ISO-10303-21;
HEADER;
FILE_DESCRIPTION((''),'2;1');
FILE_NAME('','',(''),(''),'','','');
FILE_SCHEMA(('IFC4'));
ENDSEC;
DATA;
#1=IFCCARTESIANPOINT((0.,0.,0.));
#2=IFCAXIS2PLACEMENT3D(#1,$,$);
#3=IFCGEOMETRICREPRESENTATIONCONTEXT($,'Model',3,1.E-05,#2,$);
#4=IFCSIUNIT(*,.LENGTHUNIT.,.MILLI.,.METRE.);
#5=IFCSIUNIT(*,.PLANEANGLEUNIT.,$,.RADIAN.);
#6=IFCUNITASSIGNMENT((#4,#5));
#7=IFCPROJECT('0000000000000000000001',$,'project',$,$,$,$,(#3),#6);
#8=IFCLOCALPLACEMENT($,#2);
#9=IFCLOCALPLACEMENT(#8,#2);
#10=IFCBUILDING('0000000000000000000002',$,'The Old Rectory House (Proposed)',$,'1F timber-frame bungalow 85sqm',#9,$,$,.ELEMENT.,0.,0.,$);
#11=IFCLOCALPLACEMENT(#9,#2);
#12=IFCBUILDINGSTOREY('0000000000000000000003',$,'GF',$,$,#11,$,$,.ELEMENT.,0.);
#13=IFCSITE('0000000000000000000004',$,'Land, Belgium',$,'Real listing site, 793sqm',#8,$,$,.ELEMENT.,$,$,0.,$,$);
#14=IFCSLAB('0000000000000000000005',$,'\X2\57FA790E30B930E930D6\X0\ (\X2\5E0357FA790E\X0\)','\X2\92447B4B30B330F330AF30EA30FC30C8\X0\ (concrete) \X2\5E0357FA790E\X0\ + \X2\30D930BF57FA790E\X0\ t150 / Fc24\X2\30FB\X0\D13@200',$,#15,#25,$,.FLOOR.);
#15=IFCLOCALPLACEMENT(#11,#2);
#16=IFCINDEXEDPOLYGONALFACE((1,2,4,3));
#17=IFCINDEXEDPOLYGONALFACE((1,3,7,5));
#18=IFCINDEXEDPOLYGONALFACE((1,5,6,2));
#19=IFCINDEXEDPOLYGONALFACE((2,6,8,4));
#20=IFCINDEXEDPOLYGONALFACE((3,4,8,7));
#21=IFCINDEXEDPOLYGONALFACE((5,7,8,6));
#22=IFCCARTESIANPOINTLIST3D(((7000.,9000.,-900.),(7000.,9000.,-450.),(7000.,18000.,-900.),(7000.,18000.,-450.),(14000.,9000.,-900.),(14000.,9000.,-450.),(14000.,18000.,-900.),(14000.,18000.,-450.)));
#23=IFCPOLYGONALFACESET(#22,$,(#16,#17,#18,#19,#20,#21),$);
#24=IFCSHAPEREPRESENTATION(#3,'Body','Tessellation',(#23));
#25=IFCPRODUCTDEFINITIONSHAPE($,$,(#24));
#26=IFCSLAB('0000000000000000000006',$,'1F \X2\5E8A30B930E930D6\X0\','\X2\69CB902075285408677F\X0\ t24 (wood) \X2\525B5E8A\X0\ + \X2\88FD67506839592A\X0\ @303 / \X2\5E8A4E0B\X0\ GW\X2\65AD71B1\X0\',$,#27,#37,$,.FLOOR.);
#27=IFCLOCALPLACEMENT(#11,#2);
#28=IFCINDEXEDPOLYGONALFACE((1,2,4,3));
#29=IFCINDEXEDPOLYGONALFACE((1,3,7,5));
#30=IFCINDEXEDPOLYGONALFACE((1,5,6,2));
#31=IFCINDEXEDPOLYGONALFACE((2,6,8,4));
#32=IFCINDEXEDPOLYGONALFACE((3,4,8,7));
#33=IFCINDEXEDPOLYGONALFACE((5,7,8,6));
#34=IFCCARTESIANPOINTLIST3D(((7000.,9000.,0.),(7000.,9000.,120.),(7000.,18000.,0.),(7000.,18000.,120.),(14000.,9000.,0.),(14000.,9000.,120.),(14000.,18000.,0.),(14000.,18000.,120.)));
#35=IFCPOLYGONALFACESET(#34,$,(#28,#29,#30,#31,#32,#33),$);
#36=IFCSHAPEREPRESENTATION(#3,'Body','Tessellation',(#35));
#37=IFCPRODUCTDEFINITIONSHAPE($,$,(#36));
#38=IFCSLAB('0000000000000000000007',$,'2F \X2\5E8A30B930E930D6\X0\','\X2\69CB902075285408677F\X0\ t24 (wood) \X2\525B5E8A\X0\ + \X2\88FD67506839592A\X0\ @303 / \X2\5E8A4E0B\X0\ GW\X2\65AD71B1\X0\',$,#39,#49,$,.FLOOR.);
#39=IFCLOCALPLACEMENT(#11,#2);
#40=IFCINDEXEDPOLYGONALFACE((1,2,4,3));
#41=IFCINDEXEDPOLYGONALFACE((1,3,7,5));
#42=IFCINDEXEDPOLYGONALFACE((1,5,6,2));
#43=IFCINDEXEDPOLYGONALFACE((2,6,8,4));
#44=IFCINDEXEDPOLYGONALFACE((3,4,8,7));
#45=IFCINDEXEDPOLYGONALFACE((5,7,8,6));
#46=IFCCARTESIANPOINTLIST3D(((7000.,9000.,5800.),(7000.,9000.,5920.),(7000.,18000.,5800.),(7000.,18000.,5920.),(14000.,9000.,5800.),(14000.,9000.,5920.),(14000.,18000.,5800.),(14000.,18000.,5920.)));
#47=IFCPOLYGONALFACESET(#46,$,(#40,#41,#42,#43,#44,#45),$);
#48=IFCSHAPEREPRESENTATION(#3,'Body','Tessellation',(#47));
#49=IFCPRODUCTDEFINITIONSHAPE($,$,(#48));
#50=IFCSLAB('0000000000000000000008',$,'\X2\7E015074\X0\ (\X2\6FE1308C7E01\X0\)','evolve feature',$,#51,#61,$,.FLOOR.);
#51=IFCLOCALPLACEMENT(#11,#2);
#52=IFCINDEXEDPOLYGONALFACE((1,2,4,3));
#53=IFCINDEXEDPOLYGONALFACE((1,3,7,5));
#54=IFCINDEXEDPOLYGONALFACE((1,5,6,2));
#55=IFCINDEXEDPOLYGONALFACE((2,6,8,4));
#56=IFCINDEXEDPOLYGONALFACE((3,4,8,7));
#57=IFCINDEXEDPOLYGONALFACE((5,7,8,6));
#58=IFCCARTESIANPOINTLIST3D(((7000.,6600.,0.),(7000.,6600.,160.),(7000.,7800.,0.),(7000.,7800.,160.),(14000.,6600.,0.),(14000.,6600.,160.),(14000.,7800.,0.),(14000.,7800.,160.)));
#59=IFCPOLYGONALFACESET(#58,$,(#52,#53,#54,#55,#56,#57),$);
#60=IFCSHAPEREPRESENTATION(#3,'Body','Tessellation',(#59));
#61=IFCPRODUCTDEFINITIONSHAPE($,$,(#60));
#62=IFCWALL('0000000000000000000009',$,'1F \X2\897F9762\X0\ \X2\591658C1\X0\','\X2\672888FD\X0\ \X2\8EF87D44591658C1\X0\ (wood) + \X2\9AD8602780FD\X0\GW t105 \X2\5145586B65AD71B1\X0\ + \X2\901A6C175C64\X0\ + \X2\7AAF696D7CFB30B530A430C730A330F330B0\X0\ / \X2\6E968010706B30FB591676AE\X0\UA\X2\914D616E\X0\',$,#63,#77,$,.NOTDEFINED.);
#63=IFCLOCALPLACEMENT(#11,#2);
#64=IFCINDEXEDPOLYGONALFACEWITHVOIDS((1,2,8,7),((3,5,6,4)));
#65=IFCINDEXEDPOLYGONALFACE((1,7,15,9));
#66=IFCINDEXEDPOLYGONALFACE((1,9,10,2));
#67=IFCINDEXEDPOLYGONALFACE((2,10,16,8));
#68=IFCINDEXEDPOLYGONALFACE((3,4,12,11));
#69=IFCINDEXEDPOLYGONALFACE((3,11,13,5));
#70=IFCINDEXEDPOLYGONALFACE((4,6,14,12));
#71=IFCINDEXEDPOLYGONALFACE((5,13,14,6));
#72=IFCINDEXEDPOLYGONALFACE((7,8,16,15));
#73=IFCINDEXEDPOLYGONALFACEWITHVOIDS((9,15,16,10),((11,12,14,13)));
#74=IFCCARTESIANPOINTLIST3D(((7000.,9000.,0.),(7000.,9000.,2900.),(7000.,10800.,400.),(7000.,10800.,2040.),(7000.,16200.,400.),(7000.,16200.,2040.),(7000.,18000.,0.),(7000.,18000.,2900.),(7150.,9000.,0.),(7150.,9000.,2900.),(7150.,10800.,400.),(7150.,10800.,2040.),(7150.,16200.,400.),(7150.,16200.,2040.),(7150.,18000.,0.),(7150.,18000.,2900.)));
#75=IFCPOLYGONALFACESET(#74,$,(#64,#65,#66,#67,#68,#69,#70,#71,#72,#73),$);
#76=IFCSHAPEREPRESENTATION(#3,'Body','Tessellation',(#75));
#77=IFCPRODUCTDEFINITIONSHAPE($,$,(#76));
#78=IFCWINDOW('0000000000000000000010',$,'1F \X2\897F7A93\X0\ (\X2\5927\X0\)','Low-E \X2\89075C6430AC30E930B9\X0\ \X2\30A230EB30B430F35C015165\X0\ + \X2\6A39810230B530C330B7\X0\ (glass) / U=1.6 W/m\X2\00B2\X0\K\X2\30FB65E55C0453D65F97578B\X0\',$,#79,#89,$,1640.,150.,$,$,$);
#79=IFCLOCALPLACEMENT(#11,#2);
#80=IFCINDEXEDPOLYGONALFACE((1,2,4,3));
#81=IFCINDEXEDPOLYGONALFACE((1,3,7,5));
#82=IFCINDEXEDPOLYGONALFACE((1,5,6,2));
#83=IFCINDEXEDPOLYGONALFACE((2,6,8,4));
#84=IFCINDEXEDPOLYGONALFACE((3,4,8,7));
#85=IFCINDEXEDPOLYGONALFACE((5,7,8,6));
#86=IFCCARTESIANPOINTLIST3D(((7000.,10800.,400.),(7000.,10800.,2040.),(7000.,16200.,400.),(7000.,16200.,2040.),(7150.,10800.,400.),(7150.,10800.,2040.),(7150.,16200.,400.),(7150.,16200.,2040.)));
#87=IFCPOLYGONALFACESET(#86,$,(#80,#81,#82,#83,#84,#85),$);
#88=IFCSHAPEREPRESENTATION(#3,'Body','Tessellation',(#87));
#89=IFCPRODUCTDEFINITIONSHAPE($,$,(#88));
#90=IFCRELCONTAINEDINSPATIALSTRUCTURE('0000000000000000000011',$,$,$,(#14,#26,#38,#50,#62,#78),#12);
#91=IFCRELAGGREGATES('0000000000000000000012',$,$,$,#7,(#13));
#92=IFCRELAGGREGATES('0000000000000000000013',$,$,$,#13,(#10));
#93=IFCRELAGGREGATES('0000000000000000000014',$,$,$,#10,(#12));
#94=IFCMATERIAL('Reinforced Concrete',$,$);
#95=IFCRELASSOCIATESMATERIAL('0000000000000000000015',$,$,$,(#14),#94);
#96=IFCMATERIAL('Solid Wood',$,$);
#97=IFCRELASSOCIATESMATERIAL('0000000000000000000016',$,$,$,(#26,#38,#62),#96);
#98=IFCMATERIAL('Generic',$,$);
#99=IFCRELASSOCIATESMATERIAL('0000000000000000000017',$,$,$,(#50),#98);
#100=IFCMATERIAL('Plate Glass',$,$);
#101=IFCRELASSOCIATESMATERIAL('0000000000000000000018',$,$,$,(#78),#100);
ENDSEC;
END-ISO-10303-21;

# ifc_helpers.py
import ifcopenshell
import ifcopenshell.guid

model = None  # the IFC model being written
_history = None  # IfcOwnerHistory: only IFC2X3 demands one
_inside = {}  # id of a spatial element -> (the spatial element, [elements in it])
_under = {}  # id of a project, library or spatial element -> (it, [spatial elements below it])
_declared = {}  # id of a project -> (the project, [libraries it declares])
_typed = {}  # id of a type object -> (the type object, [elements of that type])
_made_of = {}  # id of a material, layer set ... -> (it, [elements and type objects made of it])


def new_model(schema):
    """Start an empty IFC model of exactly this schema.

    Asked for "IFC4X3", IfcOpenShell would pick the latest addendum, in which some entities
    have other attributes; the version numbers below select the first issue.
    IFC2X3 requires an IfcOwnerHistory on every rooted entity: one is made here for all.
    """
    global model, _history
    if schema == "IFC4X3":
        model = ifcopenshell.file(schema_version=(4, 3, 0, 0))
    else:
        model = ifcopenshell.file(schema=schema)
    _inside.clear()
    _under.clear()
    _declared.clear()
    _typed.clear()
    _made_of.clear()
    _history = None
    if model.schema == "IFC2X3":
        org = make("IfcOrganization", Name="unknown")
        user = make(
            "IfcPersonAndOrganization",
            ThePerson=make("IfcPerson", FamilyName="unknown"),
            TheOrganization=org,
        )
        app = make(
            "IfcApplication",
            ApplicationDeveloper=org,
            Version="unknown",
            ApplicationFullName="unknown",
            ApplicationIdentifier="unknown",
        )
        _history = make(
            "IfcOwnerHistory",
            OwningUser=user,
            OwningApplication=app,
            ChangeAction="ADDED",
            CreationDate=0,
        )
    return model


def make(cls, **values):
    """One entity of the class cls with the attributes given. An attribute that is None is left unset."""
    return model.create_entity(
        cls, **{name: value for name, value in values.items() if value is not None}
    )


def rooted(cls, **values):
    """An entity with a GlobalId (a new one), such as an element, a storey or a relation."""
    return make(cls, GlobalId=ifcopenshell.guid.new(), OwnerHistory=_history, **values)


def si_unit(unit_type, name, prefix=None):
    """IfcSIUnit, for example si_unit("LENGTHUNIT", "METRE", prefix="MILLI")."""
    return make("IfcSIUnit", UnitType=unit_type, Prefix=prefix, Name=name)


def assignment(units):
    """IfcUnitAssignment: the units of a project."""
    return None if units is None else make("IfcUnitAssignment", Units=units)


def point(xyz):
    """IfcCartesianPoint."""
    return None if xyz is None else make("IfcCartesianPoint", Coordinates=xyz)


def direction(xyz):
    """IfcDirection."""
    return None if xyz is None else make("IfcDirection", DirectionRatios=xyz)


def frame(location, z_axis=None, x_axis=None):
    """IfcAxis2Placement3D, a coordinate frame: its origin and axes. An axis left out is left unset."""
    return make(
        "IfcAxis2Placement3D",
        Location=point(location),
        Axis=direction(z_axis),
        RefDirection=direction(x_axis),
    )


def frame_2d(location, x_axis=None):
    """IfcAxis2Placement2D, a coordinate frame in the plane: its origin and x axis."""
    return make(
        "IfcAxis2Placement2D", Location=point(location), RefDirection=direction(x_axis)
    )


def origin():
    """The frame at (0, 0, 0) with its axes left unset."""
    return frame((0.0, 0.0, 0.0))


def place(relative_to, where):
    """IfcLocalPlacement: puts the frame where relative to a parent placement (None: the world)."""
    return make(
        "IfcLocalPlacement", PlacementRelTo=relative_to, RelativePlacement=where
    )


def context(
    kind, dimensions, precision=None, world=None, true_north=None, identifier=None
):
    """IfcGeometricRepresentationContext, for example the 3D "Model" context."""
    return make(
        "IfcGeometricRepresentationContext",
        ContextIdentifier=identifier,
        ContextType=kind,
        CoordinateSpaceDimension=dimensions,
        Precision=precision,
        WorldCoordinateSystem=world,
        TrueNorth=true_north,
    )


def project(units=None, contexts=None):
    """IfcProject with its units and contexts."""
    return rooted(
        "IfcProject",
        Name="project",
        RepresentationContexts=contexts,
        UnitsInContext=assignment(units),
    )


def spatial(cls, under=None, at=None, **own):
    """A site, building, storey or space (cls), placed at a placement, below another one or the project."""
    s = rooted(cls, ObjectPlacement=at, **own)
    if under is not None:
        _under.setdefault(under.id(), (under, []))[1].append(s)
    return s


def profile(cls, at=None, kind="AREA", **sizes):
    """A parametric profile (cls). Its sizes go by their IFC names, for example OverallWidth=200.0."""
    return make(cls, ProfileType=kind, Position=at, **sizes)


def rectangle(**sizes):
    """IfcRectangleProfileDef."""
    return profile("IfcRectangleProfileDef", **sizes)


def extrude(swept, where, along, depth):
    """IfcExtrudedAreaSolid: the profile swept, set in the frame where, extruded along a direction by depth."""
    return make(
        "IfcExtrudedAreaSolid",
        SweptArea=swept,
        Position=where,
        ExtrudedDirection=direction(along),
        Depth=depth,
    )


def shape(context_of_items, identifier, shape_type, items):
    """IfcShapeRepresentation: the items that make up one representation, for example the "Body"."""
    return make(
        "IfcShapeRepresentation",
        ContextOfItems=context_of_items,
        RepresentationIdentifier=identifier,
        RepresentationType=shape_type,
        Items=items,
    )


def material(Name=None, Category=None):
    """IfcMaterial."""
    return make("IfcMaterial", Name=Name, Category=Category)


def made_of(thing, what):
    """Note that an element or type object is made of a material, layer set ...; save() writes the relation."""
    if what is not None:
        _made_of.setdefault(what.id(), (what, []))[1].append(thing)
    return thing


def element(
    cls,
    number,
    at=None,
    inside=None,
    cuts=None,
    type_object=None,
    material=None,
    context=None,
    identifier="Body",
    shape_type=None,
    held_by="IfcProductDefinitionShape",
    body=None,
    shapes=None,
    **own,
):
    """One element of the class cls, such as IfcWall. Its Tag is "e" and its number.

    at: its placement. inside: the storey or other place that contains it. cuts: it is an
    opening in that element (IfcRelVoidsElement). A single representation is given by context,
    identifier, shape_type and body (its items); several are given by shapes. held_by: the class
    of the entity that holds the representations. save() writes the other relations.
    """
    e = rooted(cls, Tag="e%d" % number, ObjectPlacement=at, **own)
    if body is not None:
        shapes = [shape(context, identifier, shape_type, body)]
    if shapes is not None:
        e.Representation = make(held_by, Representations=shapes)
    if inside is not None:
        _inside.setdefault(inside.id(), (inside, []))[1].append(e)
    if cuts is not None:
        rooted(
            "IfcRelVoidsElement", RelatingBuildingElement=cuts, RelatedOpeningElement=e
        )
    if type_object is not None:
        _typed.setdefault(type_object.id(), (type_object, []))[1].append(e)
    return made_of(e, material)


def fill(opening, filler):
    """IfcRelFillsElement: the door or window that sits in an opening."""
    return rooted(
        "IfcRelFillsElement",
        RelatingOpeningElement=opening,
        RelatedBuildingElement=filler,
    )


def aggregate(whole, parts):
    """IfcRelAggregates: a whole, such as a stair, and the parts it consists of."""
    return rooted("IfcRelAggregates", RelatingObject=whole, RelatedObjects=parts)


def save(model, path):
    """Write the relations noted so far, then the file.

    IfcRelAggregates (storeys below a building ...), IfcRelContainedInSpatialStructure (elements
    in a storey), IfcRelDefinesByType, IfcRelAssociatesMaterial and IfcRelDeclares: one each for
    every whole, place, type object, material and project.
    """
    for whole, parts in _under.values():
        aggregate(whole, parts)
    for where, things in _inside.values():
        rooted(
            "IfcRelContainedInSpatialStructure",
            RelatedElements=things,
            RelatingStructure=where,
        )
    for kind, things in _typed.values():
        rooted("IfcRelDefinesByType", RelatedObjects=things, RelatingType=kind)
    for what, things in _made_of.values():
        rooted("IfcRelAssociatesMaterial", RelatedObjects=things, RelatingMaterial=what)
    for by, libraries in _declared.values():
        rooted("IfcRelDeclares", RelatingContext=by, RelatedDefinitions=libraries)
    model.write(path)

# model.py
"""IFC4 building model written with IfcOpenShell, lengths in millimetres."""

from ifc_helpers import new_model, si_unit, frame, frame_2d, origin, place, context, project, spatial, rectangle, extrude, material, element, fill, save


model = new_model("IFC4")

# Units and contexts
model_context = context("Model", 3, precision=1e-05, world=origin())
ifc_project = project(units=[si_unit("LENGTHUNIT", "METRE", prefix="MILLI"), si_unit("PLANEANGLEUNIT", "RADIAN")], contexts=[model_context])

# Site, building, storey
site_placement = place(None, origin())
site = spatial("IfcSite", under=ifc_project, at=site_placement, Name="Land, Belgium", ObjectType="Real listing site, 793sqm", CompositionType="ELEMENT", RefElevation=0.0)
building_placement = place(site_placement, origin())
building = spatial("IfcBuilding", under=site, at=building_placement, Name="The Old Rectory House (Proposed)", ObjectType="1F timber-frame bungalow 85sqm", CompositionType="ELEMENT", ElevationOfRefHeight=0.0, ElevationOfTerrain=0.0)
storey_placement = place(building_placement, origin())
storey = spatial("IfcBuildingStorey", under=building, at=storey_placement, Name="GF", CompositionType="ELEMENT", Elevation=0.0)

# Slabs
ifc_material_1 = material(Name="Reinforced Concrete")
slab_1_placement = place(storey_placement, frame((3500.0, 4500.0, -450.0)))
element("IfcSlab", 1, at=slab_1_placement, inside=storey, material=ifc_material_1, Name="基礎スラブ (布基礎)", Description="鉄筋コンクリート (concrete) 布基礎 + ベタ基礎 t150 / Fc24・D13@200", PredefinedType="FLOOR", context=model_context, shape_type="SweptSolid", body=[
    extrude(rectangle(XDim=7000.0, YDim=9000.0, at=frame_2d((3500.0, 4500.0))), frame((3500.0, 4500.0, -450.0)), (0.0, 0.0, 1.0), 450.0),
])
ifc_material_2 = material(Name="Solid Wood")
slab_2_placement = place(storey_placement, frame((3500.0, 4500.0, 0.0)))
element("IfcSlab", 2, at=slab_2_placement, inside=storey, material=ifc_material_2, Name="1F 床スラブ", Description="構造用合板 t24 (wood) 剛床 + 製材根太 @303 / 床下 GW断熱", PredefinedType="FLOOR", context=model_context, shape_type="SweptSolid", body=[
    extrude(rectangle(XDim=7000.0, YDim=9000.0, at=frame_2d((3500.0, 4500.0))), frame((3500.0, 4500.0, 0.0)), (0.0, 0.0, 1.0), 120.0),
])
slab_3_placement = place(storey_placement, frame((3500.0, 4500.0, 2900.0)))
element("IfcSlab", 3, at=slab_3_placement, inside=storey, material=ifc_material_2, Name="2F 床スラブ", Description="構造用合板 t24 (wood) 剛床 + 製材根太 @303 / 床下 GW断熱", PredefinedType="FLOOR", context=model_context, shape_type="SweptSolid", body=[
    extrude(rectangle(XDim=7000.0, YDim=9000.0, at=frame_2d((3500.0, 4500.0))), frame((3500.0, 4500.0, 2900.0)), (0.0, 0.0, 1.0), 120.0),
])
ifc_material_3 = material(Name="Generic")
slab_4_placement = place(storey_placement, frame((3500.0, 3300.0, 0.0)))
element("IfcSlab", 4, at=slab_4_placement, inside=storey, material=ifc_material_3, Name="縁側 (濡れ縁)", Description="evolve feature", PredefinedType="FLOOR", context=model_context, shape_type="SweptSolid", body=[
    extrude(rectangle(XDim=7000.0, YDim=1200.0, at=frame_2d((3500.0, 600.0))), frame((3500.0, 3300.0, 0.0)), (0.0, 0.0, 1.0), 160.0),
])

# Shared definitions
ifc_material_4 = material(Name="Plate Glass")

# Wall, opening, window
wall_1_placement = place(storey_placement, frame((3500.0, 4500.0, 0.0)))
wall_1 = element("IfcWall", 5, at=wall_1_placement, inside=storey, material=ifc_material_2, Name="1F 西面 外壁", Description="木製 軸組外壁 (wood) + 高性能GW t105 充填断熱 + 通気層 + 窯業系サイディング / 準耐火・外皮UA配慮", PredefinedType="NOTDEFINED", context=model_context, shape_type="SweptSolid", body=[
    extrude(rectangle(XDim=150.0, YDim=9000.0, at=frame_2d((75.0, 4500.0))), frame((3500.0, 4500.0, 0.0)), (0.0, 0.0, 1.0), 2900.0),
])
opening_1_placement = place(storey_placement, frame((3500.0, 5400.0, 200.0)))
opening_1 = element("IfcOpeningElement", 6, at=opening_1_placement, cuts=wall_1, PredefinedType="NOTDEFINED", context=model_context, shape_type="SweptSolid", body=[
    extrude(rectangle(XDim=150.0, YDim=5400.0, at=frame_2d((75.0, 2700.0))), frame((3500.0, 5400.0, 200.0)), (0.0, 0.0, 1.0), 1640.0),
])
window_1_placement = place(storey_placement, frame((3500.0, 5400.0, 200.0)))
window_1 = element("IfcWindow", 7, at=window_1_placement, inside=storey, material=ifc_material_4, Name="1F 西窓 (大)", Description="Low-E 複層ガラス アルゴン封入 + 樹脂サッシ (glass) / U=1.6 W/m²K・日射取得型", OverallHeight=1640.0, OverallWidth=150.0, context=model_context, shape_type="SweptSolid", body=[
    extrude(rectangle(XDim=150.0, YDim=5400.0, at=frame_2d((75.0, 2700.0))), frame((3500.0, 5400.0, 200.0)), (0.0, 0.0, 1.0), 1640.0),
])
fill(opening_1, window_1)

save(model, "model.ifc")
